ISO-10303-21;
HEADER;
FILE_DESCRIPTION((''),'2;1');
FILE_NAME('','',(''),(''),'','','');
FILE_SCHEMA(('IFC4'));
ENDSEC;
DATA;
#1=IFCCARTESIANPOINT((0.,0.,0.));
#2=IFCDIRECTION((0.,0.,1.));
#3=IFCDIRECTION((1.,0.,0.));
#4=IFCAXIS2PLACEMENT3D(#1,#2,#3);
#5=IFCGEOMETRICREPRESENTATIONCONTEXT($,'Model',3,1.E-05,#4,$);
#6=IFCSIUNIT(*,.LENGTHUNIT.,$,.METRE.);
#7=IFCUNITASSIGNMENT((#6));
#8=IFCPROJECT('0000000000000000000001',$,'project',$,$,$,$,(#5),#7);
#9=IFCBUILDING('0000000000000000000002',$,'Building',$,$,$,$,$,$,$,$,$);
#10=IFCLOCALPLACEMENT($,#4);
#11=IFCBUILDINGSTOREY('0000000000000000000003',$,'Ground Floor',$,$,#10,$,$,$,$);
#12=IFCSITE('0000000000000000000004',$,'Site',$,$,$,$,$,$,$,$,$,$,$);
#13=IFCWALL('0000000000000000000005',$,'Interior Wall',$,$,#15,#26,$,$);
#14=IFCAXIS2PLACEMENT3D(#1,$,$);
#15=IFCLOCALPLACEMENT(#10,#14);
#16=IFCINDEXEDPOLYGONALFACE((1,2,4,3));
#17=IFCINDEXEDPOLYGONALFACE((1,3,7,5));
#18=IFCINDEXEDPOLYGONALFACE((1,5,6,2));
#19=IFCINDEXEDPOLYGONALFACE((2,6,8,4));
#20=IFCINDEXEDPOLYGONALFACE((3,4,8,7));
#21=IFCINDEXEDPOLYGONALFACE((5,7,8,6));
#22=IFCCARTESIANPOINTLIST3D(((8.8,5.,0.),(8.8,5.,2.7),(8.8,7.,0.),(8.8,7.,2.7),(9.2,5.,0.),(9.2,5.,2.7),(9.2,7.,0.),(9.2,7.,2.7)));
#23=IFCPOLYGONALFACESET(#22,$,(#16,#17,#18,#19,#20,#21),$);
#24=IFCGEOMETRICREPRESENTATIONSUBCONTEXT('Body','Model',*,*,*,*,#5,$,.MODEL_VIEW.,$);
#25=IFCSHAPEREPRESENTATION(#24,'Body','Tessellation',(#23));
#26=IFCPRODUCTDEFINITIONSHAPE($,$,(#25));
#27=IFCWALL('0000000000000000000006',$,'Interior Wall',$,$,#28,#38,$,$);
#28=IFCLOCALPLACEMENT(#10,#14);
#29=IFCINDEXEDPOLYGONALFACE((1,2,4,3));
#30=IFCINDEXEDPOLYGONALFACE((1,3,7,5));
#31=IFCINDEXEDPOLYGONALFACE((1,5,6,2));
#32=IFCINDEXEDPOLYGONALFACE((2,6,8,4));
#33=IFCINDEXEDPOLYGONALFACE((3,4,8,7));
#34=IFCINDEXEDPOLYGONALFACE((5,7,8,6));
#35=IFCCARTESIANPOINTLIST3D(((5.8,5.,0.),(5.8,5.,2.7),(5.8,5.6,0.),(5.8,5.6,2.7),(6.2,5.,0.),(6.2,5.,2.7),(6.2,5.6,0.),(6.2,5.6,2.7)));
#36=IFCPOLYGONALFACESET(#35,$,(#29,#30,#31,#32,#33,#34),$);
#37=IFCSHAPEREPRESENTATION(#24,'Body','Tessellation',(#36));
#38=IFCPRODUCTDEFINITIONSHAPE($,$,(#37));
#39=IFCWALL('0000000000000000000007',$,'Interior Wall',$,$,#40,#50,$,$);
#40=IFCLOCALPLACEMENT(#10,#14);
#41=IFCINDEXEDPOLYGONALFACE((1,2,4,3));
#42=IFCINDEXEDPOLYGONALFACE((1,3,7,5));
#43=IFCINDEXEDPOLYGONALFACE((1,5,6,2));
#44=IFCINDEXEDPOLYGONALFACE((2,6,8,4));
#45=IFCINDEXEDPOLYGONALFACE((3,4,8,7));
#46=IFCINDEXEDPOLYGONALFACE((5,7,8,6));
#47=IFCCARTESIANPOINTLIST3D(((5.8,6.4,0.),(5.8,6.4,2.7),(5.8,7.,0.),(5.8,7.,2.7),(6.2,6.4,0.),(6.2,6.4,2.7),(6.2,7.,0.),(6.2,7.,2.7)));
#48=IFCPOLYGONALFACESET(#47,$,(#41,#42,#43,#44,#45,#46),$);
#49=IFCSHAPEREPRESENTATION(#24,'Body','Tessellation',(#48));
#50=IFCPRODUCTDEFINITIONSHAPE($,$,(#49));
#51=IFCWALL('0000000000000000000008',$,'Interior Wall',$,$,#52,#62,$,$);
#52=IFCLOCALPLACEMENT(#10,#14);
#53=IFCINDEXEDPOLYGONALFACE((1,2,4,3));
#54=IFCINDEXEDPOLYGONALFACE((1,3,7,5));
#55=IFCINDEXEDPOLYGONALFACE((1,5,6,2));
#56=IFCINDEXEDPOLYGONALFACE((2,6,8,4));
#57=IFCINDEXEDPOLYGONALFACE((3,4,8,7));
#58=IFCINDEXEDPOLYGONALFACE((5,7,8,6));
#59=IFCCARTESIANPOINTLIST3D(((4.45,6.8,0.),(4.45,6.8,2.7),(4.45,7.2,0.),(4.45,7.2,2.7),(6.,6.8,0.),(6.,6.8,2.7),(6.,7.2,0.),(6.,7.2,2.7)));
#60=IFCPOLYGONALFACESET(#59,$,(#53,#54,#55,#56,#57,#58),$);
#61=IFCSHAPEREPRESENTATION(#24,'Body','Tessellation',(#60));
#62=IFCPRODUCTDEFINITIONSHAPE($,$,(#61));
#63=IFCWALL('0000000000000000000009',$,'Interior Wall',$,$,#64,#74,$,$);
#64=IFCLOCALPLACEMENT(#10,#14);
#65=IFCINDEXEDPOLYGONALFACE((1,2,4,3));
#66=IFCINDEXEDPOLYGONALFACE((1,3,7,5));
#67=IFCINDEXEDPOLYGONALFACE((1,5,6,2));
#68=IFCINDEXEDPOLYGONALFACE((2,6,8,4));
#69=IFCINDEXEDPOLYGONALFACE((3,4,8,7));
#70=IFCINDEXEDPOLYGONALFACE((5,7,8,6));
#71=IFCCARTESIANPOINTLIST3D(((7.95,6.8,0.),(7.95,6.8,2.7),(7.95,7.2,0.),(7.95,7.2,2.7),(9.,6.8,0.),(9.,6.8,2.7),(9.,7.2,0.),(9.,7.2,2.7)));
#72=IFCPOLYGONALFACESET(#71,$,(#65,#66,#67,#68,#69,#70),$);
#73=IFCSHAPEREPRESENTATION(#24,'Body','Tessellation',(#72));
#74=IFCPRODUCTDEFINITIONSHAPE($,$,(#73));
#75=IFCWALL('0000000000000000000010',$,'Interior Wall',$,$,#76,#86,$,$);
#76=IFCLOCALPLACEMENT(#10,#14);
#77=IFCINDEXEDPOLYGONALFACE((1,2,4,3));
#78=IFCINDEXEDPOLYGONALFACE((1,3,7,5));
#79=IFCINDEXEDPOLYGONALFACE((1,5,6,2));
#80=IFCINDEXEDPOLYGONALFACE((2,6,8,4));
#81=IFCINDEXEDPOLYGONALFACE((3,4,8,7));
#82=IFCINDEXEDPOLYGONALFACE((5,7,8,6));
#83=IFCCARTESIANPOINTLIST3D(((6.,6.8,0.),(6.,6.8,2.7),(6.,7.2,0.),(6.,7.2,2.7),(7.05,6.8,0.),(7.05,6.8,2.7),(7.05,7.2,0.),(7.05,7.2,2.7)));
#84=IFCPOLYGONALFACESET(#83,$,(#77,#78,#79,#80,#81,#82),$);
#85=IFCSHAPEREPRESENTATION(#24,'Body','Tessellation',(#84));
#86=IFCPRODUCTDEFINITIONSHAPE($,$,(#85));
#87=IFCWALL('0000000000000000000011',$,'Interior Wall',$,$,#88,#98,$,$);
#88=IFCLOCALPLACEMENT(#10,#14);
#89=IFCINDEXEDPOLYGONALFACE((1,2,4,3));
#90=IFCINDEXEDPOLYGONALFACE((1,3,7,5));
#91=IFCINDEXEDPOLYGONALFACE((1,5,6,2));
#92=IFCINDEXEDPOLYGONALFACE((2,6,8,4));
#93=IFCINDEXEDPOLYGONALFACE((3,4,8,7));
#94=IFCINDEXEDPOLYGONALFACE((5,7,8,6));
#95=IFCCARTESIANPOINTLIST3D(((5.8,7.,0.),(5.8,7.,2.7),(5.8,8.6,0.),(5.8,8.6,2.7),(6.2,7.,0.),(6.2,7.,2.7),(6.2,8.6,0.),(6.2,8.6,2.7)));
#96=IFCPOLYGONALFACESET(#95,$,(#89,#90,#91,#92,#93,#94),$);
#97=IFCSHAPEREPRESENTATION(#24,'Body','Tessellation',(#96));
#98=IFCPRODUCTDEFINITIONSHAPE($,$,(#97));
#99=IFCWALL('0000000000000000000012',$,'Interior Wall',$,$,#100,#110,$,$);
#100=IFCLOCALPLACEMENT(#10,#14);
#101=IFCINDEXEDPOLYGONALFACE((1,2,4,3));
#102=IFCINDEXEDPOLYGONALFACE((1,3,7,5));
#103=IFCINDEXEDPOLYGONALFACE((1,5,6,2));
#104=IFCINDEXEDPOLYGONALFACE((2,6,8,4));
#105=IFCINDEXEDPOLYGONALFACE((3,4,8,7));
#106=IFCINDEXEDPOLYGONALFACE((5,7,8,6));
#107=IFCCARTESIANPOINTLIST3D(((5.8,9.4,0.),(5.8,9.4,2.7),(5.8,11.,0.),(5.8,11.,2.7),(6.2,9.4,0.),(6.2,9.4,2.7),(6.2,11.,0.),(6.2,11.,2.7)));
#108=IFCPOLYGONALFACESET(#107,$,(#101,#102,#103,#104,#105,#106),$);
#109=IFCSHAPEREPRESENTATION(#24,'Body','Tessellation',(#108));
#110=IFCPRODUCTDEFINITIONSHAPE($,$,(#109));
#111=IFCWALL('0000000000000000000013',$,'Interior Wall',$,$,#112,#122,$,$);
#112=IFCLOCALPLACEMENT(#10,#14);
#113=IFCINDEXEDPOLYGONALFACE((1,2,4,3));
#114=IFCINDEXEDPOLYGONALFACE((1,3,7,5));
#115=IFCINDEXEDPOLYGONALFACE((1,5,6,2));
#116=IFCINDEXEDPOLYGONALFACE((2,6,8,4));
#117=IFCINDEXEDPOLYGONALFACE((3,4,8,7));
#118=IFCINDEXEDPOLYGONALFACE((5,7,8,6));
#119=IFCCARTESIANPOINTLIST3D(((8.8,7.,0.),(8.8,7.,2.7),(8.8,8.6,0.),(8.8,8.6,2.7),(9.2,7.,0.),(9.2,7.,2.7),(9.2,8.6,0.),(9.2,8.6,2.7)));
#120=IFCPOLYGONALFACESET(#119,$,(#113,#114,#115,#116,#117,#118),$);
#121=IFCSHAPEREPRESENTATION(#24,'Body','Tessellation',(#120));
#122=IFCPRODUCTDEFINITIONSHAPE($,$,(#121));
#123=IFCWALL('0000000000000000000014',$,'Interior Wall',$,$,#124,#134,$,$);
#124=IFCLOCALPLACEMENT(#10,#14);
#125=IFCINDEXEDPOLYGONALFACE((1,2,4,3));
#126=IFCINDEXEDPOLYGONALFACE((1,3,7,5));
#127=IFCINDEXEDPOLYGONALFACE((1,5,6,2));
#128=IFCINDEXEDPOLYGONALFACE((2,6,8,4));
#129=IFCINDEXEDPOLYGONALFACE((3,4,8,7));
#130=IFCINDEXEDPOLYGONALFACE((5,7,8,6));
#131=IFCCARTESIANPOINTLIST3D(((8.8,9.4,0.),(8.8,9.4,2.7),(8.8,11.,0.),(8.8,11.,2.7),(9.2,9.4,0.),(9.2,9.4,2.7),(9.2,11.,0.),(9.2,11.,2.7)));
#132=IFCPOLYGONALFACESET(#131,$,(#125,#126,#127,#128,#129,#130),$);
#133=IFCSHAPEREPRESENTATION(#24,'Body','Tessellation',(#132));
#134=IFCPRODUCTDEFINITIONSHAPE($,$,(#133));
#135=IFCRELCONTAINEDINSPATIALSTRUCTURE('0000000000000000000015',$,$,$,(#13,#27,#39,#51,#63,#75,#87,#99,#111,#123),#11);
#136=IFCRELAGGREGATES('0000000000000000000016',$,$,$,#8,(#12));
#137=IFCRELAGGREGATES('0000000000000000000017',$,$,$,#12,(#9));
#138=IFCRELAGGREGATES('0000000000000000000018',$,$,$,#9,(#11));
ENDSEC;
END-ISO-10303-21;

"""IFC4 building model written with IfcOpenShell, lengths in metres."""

from ifc_helpers import new_model, si_unit, frame, origin_with_axes, place, context, subcontext, project, spatial, indexed_curve, outline, extrude, element, save


model = new_model("IFC4")

# Units and contexts
model_context = context("Model", 3, precision=1e-05, world=origin_with_axes())
body_context = subcontext(model_context, "Body", "Model", "MODEL_VIEW")
ifc_project = project(units=[si_unit("LENGTHUNIT", "METRE")], contexts=[model_context])

# Site, building, storey
site = spatial("IfcSite", under=ifc_project, Name="Site")
building = spatial("IfcBuilding", under=site, Name="Building")
storey_placement = place(None, origin_with_axes())
storey = spatial("IfcBuildingStorey", under=building, at=storey_placement, Name="Ground Floor")

# Walls
wall_1_placement = place(storey_placement, frame((9.0, 7.0, 0.0), z_axis=(0.0, 0.0, 1.0), x_axis=(0.0, -1.0, 0.0)))
element("IfcWall", 1, at=wall_1_placement, inside=storey, Name="Interior Wall", context=body_context, shape_type="SweptSolid", body=[
    extrude(outline(indexed_curve([(0.0, 0.0), (0.0, 0.4), (2.0, 0.4), (2.0, 0.0), (0.0, 0.0)], self_intersect=False)), frame((0.0, -0.2, 0.0), z_axis=(0.0, 0.0, 1.0), x_axis=(1.0, 0.0, 0.0)), (0.0, 0.0, 1.0), 2.7),
])
for number, where, z_axis, x_axis, name in (
    (2, (6.0, 5.0, 0.0), (0.0, 0.0, 1.0), (0.0, 1.0, 0.0), "Interior Wall"),
    (3, (6.0, 6.4, 0.0), (0.0, 0.0, 1.0), (0.0, 1.0, 0.0), "Interior Wall"),
):
    element("IfcWall", number, at=place(storey_placement, frame(where, z_axis=z_axis, x_axis=x_axis)), inside=storey, Name=name, context=body_context, shape_type="SweptSolid", body=[
        extrude(outline(indexed_curve([(0.0, 0.0), (0.0, 0.4), (0.6, 0.4), (0.6, 0.0), (0.0, 0.0)], self_intersect=False)), frame((0.0, -0.2, 0.0), z_axis=(0.0, 0.0, 1.0), x_axis=(1.0, 0.0, 0.0)), (0.0, 0.0, 1.0), 2.7),
    ])
wall_2_placement = place(storey_placement, frame((6.0, 7.0, 0.0), z_axis=(0.0, 0.0, 1.0), x_axis=(-1.0, 0.0, 0.0)))
element("IfcWall", 4, at=wall_2_placement, inside=storey, Name="Interior Wall", context=body_context, shape_type="SweptSolid", body=[
    extrude(outline(indexed_curve([(0.0, 0.0), (0.0, 0.4), (1.55, 0.4), (1.55, 0.0), (0.0, 0.0)], self_intersect=False)), frame((0.0, -0.2, 0.0), z_axis=(0.0, 0.0, 1.0), x_axis=(1.0, 0.0, 0.0)), (0.0, 0.0, 1.0), 2.7),
])
for number, where, z_axis, x_axis, name in (
    (5, (9.0, 7.0, 0.0), (0.0, 0.0, 1.0), (-1.0, 0.0, 0.0), "Interior Wall"),
    (6, (7.05, 7.0, 0.0), (0.0, 0.0, 1.0), (-1.0, 0.0, 0.0), "Interior Wall"),
):
    element("IfcWall", number, at=place(storey_placement, frame(where, z_axis=z_axis, x_axis=x_axis)), inside=storey, Name=name, context=body_context, shape_type="SweptSolid", body=[
        extrude(outline(indexed_curve([(0.0, 0.0), (0.0, 0.4), (1.05, 0.4), (1.05, 0.0), (0.0, 0.0)], self_intersect=False)), frame((0.0, -0.2, 0.0), z_axis=(0.0, 0.0, 1.0), x_axis=(1.0, 0.0, 0.0)), (0.0, 0.0, 1.0), 2.7),
    ])
for number, where, z_axis, x_axis, name in (
    (7, (6.0, 7.0, 0.0), (0.0, 0.0, 1.0), (0.0, 1.0, 0.0), "Interior Wall"),
    (8, (6.0, 9.4, 0.0), (0.0, 0.0, 1.0), (0.0, 1.0, 0.0), "Interior Wall"),
    (9, (9.0, 7.0, 0.0), (0.0, 0.0, 1.0), (0.0, 1.0, 0.0), "Interior Wall"),
    (10, (9.0, 9.4, 0.0), (0.0, 0.0, 1.0), (0.0, 1.0, 0.0), "Interior Wall"),
):
    element("IfcWall", number, at=place(storey_placement, frame(where, z_axis=z_axis, x_axis=x_axis)), inside=storey, Name=name, context=body_context, shape_type="SweptSolid", body=[
        extrude(outline(indexed_curve([(0.0, 0.0), (0.0, 0.4), (1.6, 0.4), (1.6, 0.0), (0.0, 0.0)], self_intersect=False)), frame((0.0, -0.2, 0.0), z_axis=(0.0, 0.0, 1.0), x_axis=(1.0, 0.0, 0.0)), (0.0, 0.0, 1.0), 2.7),
    ])

save(model, "model.ifc")
